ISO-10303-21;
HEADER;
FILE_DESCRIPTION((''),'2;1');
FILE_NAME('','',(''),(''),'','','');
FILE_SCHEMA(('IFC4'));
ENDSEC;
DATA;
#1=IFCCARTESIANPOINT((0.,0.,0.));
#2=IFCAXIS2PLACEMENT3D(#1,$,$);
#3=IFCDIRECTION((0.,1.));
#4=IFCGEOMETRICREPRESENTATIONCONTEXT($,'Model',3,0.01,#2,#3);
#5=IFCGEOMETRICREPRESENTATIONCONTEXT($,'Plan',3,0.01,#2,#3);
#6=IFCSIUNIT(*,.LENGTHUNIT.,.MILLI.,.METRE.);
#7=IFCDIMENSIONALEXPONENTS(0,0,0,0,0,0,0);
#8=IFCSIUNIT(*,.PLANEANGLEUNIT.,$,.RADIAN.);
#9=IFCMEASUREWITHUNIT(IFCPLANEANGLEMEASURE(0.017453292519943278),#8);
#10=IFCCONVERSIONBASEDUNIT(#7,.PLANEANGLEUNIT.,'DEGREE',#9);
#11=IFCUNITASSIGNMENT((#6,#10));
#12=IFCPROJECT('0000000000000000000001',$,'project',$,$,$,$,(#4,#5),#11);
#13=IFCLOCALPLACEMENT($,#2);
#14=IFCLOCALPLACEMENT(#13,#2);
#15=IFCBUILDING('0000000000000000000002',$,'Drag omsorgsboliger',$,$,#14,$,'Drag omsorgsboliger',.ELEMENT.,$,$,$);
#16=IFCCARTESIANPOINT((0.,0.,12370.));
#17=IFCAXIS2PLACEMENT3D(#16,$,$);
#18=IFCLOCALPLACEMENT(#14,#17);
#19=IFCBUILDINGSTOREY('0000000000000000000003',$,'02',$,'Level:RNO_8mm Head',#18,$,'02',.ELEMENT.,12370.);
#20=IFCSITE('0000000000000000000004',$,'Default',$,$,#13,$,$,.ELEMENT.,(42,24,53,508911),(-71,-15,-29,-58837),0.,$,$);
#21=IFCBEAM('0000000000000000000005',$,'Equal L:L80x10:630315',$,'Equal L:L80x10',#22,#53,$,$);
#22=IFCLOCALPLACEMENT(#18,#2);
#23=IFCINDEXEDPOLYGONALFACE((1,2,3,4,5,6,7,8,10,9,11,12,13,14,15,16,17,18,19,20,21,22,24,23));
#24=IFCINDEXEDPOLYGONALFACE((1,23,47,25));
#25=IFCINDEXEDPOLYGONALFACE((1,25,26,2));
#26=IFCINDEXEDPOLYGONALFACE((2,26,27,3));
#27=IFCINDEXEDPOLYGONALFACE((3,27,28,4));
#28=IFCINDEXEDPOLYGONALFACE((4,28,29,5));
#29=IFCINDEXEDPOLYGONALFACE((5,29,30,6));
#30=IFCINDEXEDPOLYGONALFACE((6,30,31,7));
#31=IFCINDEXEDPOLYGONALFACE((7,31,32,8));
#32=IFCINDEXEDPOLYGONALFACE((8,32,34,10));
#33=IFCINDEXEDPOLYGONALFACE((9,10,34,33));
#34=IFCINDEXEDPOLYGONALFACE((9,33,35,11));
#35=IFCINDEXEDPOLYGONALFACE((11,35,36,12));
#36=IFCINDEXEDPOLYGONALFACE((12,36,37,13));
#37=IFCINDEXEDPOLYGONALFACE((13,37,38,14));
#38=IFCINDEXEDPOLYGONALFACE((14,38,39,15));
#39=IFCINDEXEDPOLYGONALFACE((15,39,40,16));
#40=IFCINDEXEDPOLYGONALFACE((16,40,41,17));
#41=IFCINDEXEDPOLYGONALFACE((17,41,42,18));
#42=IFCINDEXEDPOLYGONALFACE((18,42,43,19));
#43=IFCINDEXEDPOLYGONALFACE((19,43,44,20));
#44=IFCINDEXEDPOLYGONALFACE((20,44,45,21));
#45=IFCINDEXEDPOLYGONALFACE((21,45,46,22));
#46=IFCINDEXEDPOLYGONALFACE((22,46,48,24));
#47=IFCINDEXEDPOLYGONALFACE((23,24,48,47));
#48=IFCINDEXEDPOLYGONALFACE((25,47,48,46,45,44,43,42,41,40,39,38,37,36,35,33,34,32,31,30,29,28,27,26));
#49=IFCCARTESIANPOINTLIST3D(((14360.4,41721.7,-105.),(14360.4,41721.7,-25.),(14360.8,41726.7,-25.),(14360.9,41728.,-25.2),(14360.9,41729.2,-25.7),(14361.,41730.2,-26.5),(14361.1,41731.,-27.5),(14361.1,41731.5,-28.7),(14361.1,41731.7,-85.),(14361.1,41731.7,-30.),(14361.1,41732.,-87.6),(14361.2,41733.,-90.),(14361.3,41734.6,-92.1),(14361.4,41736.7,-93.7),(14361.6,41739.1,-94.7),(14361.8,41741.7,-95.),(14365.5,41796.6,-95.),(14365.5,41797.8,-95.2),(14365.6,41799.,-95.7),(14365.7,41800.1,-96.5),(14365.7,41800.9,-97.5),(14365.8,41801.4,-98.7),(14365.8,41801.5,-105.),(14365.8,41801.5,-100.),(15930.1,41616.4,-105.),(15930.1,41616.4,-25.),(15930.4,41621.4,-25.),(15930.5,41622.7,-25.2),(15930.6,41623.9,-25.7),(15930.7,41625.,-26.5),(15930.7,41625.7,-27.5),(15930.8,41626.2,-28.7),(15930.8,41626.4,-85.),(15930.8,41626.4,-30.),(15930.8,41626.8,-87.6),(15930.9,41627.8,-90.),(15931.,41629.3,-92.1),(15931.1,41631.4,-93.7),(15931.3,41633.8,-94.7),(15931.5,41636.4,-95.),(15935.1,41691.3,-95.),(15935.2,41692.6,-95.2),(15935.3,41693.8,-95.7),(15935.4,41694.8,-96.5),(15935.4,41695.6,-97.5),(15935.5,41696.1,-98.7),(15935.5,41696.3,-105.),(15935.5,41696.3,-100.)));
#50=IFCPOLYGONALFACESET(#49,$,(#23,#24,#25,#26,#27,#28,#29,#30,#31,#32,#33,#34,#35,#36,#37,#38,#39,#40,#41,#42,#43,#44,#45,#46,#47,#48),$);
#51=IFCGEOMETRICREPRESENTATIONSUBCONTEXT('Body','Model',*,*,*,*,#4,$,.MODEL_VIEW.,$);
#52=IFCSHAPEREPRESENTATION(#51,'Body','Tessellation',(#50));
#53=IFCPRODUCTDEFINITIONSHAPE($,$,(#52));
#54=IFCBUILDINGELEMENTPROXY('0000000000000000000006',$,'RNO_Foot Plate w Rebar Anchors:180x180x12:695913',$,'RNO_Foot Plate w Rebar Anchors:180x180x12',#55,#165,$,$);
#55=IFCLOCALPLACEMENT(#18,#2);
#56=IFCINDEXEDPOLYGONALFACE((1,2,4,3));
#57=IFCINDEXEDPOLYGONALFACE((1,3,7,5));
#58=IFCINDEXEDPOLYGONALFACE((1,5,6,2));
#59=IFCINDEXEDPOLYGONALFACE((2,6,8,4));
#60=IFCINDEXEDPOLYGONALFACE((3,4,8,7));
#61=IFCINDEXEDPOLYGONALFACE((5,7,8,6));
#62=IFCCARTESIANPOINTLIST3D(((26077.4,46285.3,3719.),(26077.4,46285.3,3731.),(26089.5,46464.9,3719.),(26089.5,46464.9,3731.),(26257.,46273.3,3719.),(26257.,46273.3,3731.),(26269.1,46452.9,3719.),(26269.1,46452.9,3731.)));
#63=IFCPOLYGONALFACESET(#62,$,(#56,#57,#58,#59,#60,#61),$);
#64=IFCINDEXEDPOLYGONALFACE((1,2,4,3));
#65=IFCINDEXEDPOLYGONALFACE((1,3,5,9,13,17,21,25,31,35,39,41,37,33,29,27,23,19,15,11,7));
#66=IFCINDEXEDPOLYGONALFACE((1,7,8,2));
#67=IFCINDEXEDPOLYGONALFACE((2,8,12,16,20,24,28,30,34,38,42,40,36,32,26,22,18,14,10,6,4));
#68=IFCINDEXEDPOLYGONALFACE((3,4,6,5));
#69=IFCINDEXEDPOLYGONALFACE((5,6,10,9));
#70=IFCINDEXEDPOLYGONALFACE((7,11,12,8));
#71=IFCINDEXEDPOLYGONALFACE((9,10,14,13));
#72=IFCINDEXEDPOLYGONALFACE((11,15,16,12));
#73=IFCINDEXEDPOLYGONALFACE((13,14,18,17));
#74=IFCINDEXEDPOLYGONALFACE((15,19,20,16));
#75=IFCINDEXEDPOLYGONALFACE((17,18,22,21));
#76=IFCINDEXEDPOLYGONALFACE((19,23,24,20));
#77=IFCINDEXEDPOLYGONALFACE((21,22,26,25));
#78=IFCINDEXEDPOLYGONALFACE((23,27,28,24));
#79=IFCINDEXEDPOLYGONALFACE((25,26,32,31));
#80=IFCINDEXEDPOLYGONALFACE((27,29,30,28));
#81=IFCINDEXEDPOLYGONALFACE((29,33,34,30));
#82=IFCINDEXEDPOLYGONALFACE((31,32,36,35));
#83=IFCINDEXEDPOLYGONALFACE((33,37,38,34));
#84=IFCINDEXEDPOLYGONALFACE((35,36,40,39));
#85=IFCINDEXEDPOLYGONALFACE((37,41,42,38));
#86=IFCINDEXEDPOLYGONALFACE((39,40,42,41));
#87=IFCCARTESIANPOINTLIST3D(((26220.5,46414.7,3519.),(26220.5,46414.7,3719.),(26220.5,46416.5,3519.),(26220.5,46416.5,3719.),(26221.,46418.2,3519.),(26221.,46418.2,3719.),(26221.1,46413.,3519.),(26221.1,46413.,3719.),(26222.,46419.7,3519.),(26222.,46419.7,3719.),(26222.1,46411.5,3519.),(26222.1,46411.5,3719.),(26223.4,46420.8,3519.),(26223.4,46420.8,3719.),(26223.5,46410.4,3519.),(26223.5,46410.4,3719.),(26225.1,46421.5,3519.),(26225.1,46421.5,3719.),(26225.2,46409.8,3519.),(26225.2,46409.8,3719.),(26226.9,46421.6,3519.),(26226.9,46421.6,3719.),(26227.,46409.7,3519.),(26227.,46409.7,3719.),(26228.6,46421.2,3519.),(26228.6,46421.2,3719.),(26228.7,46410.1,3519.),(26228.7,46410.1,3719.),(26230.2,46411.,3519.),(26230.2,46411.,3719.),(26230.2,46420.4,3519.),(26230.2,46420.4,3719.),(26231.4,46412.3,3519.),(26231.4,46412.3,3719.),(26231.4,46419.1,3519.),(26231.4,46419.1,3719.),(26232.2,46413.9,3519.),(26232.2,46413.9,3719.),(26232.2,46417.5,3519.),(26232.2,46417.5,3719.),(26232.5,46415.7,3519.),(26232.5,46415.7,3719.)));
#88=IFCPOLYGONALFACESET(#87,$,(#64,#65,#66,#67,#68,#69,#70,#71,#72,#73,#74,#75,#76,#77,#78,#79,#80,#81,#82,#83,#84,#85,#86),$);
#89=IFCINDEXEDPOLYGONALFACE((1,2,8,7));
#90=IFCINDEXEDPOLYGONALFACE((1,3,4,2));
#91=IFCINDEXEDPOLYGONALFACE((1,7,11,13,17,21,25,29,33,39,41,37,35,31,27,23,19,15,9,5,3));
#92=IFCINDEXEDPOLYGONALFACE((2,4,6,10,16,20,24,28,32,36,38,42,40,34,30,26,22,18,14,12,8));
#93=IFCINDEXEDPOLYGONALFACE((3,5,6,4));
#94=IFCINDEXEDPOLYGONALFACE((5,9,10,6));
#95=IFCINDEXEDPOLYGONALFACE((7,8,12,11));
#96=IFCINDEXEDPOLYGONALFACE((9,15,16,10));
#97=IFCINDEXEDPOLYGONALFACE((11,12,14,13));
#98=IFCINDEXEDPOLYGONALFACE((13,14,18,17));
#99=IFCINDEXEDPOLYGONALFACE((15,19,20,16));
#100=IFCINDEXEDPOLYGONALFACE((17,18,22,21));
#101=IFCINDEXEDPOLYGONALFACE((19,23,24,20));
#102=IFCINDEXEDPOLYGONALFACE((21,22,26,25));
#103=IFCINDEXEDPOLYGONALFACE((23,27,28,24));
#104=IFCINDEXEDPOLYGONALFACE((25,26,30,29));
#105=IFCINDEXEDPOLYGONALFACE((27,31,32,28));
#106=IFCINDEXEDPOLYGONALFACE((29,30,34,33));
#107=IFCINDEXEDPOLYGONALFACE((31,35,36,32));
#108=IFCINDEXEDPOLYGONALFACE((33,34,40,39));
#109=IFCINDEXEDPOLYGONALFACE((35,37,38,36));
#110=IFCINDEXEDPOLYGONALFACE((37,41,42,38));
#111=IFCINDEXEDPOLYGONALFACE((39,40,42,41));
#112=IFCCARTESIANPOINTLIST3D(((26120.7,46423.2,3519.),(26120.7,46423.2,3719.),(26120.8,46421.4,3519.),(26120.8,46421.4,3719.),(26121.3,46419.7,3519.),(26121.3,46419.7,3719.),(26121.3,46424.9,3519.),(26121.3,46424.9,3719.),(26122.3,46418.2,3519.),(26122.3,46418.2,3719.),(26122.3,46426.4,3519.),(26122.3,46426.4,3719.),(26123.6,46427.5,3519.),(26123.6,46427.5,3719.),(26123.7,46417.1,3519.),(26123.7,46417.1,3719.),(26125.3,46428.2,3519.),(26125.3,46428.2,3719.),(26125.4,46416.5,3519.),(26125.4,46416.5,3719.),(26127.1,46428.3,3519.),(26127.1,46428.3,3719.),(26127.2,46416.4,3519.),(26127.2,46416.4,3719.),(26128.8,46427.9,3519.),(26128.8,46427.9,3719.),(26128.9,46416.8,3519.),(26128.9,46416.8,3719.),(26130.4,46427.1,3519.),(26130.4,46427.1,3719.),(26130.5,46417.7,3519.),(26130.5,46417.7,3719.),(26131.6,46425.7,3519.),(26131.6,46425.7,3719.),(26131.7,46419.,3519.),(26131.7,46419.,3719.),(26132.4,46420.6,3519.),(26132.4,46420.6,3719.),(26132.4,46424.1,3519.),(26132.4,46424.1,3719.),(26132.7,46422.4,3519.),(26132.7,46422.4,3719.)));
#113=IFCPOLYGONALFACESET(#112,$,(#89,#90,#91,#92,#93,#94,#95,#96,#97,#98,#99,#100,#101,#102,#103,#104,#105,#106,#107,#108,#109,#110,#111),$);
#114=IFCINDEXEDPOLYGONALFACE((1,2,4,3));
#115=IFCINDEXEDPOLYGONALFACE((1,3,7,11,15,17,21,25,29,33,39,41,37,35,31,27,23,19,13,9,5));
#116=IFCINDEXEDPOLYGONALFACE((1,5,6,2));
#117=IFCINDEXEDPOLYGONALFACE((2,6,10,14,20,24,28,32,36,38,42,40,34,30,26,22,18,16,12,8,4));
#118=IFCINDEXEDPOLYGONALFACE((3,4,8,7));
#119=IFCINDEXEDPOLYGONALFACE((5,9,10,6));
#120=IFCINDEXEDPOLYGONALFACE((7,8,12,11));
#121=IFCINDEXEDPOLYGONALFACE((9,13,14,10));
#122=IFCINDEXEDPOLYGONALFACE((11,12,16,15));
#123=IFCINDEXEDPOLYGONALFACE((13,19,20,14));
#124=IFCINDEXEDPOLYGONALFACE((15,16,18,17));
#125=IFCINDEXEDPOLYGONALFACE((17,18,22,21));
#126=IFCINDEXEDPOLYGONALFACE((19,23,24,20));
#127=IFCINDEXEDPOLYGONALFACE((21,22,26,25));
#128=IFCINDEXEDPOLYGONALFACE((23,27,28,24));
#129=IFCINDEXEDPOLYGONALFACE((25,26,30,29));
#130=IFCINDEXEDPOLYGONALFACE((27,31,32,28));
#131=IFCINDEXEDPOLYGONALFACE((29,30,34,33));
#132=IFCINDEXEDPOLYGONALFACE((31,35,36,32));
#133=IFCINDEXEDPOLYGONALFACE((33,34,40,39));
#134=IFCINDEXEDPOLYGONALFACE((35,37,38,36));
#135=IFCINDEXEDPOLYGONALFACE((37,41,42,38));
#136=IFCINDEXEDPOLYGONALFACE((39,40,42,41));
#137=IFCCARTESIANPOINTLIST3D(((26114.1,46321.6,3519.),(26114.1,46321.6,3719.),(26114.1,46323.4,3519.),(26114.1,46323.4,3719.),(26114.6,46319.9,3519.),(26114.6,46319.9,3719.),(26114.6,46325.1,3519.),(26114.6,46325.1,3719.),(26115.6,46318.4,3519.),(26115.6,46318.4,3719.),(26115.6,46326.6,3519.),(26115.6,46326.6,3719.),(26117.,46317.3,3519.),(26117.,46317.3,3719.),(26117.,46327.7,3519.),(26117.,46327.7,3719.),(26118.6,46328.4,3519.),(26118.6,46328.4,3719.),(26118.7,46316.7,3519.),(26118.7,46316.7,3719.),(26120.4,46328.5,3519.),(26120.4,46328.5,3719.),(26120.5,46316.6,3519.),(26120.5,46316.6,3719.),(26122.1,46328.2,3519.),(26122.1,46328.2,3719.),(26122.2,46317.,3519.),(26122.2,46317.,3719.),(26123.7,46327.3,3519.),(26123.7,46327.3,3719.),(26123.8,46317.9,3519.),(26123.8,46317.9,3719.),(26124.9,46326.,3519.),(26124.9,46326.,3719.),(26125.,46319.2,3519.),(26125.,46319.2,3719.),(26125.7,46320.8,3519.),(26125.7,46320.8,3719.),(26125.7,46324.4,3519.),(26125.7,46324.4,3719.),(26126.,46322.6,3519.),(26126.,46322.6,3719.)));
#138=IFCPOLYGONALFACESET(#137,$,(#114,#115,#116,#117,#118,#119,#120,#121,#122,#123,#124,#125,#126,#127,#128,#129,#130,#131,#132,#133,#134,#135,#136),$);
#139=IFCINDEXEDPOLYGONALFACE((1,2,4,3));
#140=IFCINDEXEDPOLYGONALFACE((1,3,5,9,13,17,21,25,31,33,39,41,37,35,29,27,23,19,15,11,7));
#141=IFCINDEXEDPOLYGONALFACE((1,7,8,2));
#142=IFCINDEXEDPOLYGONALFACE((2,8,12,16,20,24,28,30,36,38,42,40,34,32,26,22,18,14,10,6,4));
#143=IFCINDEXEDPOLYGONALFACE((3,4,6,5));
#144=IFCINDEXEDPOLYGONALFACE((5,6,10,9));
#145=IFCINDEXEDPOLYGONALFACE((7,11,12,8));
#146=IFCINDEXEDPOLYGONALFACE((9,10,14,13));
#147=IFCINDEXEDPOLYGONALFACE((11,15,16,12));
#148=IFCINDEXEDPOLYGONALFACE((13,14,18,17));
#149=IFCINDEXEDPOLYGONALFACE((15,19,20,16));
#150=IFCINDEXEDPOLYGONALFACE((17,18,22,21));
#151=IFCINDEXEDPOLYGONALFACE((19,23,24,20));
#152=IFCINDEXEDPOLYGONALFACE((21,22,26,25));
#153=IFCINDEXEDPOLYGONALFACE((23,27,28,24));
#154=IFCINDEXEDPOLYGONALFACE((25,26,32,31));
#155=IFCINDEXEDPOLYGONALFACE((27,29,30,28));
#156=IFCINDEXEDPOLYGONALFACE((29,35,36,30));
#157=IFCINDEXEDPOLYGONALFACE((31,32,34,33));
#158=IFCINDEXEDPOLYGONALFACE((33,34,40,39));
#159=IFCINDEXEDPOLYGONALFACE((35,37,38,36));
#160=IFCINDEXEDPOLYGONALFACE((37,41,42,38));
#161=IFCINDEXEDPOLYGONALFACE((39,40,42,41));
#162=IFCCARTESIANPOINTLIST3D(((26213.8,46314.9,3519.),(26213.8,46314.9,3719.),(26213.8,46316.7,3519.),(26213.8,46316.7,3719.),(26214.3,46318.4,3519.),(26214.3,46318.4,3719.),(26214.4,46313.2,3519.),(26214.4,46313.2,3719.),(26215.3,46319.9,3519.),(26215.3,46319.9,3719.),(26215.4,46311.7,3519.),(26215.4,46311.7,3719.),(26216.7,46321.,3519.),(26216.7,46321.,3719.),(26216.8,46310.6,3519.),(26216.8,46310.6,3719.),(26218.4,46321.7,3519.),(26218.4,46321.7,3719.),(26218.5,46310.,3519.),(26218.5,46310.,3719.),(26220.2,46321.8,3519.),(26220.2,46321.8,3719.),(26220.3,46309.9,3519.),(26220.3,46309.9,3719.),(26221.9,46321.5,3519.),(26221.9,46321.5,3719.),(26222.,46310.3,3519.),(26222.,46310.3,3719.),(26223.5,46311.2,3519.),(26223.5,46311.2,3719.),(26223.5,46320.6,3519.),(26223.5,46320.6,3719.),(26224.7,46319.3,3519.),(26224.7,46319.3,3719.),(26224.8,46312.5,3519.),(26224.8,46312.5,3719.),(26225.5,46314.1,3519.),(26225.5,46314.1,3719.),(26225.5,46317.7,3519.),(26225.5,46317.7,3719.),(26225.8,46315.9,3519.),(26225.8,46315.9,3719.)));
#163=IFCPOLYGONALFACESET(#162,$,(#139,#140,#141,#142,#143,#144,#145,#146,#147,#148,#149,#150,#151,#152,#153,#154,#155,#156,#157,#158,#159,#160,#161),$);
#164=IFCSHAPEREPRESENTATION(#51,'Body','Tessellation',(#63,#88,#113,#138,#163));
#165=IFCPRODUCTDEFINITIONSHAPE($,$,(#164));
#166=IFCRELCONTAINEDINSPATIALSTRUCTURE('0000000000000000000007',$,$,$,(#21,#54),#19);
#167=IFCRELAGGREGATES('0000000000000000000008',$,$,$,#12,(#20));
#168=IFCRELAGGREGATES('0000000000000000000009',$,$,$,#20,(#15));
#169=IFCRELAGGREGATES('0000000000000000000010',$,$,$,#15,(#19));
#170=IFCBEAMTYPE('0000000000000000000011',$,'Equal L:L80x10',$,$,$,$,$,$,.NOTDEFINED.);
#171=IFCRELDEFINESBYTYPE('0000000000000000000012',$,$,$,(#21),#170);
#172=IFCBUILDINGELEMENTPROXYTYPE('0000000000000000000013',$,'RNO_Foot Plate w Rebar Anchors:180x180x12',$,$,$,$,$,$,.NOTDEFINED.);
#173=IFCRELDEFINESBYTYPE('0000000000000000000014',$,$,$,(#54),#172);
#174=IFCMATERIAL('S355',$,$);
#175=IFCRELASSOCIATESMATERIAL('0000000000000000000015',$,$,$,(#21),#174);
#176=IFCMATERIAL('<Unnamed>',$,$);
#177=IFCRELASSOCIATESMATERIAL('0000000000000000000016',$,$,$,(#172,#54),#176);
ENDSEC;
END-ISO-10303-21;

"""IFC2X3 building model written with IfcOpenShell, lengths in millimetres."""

from ifc_helpers import new_model, entity, si_unit, converted_unit, direction, frame, frame_2d, origin, origin_2d_with_axis, place, context, subcontext, project, spatial, polyline, circle_curve, parameter, trimmed, segment, composite_curve, rectangle, circle, outline, extrude, source, transform, mapped, material, type_object, type_shapes, element, save


model = new_model("IFC2X3")

# Units and contexts
model_context = context("Model", 3, precision=0.01, world=origin(), true_north=direction((0.0, 1.0)))
plan_context = context("Plan", 3, precision=0.01, world=origin(), true_north=direction((0.0, 1.0)))
body_context = subcontext(model_context, "Body", "Model", "MODEL_VIEW")
ifc_project = project(units=[si_unit("LENGTHUNIT", "METRE", prefix="MILLI"), converted_unit("PLANEANGLEUNIT", "DEGREE", entity("IfcPlaneAngleMeasure", 0.017453292519943278), si_unit("PLANEANGLEUNIT", "RADIAN"), dimensions=[0, 0, 0, 0, 0, 0, 0])], contexts=[model_context, plan_context])

# Site, building, storey
site_placement = place(None, origin())
site = spatial("IfcSite", under=ifc_project, at=site_placement, Name="Default", CompositionType="ELEMENT", RefLatitude=(42, 24, 53, 508911), RefLongitude=(-71, -15, -29, -58837), RefElevation=0.0)
building_placement = place(site_placement, origin())
building = spatial("IfcBuilding", under=site, at=building_placement, Name="Drag omsorgsboliger", LongName="Drag omsorgsboliger", CompositionType="ELEMENT")
storey_placement = place(building_placement, frame((0.0, 0.0, 12370.0)))
storey = spatial("IfcBuildingStorey", under=building, at=storey_placement, Name="02", ObjectType="Level:RNO_8mm Head", LongName="02", CompositionType="ELEMENT", Elevation=12370.0)

# Beam
ifc_material_1 = material(Name="S355")
ifc_material_2 = material(Name="<Unnamed>")
beam_type_1 = type_object("IfcBeamType", Name="Equal L:L80x10", PredefinedType="NOTDEFINED")
beam_1_placement = place(storey_placement, frame((16091.4, 41629.1, -25.0), z_axis=(0.0, 0.0, 1.0), x_axis=(-0.997758, 0.066923, 0.0)))
element("IfcBeam", 1, at=beam_1_placement, inside=storey, type_object=beam_type_1, material=ifc_material_1, Name="Equal L:L80x10:630315", ObjectType="Equal L:L80x10", context=body_context, shape_type="SweptSolid", body=[
    extrude(outline(composite_curve([segment(polyline([(26.1, -48.9), (31.1, -48.9)]), True, "CONTINUOUS"), segment(polyline([(31.1, -48.9), (31.1, 31.1)]), True, "CONTINUOUS"), segment(polyline([(31.1, 31.1), (-48.9, 31.1)]), True, "CONTINUOUS"), segment(polyline([(-48.9, 31.1), (-48.9, 26.1)]), True, "CONTINUOUS"), segment(trimmed(circle_curve(frame_2d((-43.9, 26.1), x_axis=(-1.0, 0.0)), 5.0), [parameter(0.0)], [parameter(90.0)], True, "PARAMETER"), True, "CONTINUOUS"), segment(polyline([(-43.9, 21.1), (11.1, 21.1)]), True, "CONTINUOUS"), segment(trimmed(circle_curve(frame_2d((11.1, 11.1), x_axis=(0.0, 1.0)), 10.0), [parameter(270.0)], [parameter(0.0)], True, "PARAMETER"), False, "CONTINUOUS"), segment(polyline([(21.1, 11.1), (21.1, -43.9)]), True, "CONTINUOUS"), segment(trimmed(circle_curve(frame_2d((26.1, -43.9), x_axis=(-1.0, 0.0)), 5.0), [parameter(0.0)], [parameter(90.0)], True, "PARAMETER"), True, "CONTINUOUS")], self_intersect=False)), frame((160.1, -7.7, -48.9), z_axis=(1.0, 0.0, 0.0), x_axis=(0.0, 0.0, -1.0)), (0.0, 0.0, 1.0), 1573.2),
])

# Building element proxy
building_element_proxy_type = type_object("IfcBuildingElementProxyType", Name="RNO_Foot Plate w Rebar Anchors:180x180x12", PredefinedType="NOTDEFINED", material=ifc_material_2)
shared_shape_1 = source(origin(), body_context, "Body", "SweptSolid", [
    extrude(rectangle(XDim=180.0, YDim=180.0, at=origin_2d_with_axis()), frame((-90.0, 20.0, -12.0), z_axis=(0.0, 0.0, 1.0), x_axis=(-1.0, 0.0, 0.0)), (0.0, 0.0, 1.0), 12.0),
    extrude(circle(Radius=6.0, at=frame_2d((0.0, 0.0), x_axis=(1.0, 0.0))), frame((-40.0, -30.0, -212.0)), (0.0, 0.0, 1.0), 200.0),
    extrude(circle(Radius=6.0, at=frame_2d((0.0, 0.0), x_axis=(1.0, 0.0))), frame((-40.0, 70.0, -212.0)), (0.0, 0.0, 1.0), 200.0),
    extrude(circle(Radius=6.0, at=frame_2d((0.0, 0.0), x_axis=(1.0, 0.0))), frame((-140.0, 70.0, -212.0)), (0.0, 0.0, 1.0), 200.0),
    extrude(circle(Radius=6.0, at=frame_2d((0.0, 0.0), x_axis=(1.0, 0.0))), frame((-140.0, -30.0, -212.0)), (0.0, 0.0, 1.0), 200.0),
])
type_shapes(building_element_proxy_type, [shared_shape_1])
proxy_placement = place(storey_placement, frame((26199.2, 46457.6, 3731.0), z_axis=(0.0, 0.0, 1.0), x_axis=(0.066923, 0.997758, 0.0)))
element("IfcBuildingElementProxy", 2, at=proxy_placement, inside=storey, type_object=building_element_proxy_type, material=ifc_material_2, Name="RNO_Foot Plate w Rebar Anchors:180x180x12:695913", ObjectType="RNO_Foot Plate w Rebar Anchors:180x180x12", context=body_context, shape_type="MappedRepresentation", body=[
    mapped(shared_shape_1, transform((0.0, 0.0, 0.0), scale=1.0)),
])

save(model, "model.ifc")
